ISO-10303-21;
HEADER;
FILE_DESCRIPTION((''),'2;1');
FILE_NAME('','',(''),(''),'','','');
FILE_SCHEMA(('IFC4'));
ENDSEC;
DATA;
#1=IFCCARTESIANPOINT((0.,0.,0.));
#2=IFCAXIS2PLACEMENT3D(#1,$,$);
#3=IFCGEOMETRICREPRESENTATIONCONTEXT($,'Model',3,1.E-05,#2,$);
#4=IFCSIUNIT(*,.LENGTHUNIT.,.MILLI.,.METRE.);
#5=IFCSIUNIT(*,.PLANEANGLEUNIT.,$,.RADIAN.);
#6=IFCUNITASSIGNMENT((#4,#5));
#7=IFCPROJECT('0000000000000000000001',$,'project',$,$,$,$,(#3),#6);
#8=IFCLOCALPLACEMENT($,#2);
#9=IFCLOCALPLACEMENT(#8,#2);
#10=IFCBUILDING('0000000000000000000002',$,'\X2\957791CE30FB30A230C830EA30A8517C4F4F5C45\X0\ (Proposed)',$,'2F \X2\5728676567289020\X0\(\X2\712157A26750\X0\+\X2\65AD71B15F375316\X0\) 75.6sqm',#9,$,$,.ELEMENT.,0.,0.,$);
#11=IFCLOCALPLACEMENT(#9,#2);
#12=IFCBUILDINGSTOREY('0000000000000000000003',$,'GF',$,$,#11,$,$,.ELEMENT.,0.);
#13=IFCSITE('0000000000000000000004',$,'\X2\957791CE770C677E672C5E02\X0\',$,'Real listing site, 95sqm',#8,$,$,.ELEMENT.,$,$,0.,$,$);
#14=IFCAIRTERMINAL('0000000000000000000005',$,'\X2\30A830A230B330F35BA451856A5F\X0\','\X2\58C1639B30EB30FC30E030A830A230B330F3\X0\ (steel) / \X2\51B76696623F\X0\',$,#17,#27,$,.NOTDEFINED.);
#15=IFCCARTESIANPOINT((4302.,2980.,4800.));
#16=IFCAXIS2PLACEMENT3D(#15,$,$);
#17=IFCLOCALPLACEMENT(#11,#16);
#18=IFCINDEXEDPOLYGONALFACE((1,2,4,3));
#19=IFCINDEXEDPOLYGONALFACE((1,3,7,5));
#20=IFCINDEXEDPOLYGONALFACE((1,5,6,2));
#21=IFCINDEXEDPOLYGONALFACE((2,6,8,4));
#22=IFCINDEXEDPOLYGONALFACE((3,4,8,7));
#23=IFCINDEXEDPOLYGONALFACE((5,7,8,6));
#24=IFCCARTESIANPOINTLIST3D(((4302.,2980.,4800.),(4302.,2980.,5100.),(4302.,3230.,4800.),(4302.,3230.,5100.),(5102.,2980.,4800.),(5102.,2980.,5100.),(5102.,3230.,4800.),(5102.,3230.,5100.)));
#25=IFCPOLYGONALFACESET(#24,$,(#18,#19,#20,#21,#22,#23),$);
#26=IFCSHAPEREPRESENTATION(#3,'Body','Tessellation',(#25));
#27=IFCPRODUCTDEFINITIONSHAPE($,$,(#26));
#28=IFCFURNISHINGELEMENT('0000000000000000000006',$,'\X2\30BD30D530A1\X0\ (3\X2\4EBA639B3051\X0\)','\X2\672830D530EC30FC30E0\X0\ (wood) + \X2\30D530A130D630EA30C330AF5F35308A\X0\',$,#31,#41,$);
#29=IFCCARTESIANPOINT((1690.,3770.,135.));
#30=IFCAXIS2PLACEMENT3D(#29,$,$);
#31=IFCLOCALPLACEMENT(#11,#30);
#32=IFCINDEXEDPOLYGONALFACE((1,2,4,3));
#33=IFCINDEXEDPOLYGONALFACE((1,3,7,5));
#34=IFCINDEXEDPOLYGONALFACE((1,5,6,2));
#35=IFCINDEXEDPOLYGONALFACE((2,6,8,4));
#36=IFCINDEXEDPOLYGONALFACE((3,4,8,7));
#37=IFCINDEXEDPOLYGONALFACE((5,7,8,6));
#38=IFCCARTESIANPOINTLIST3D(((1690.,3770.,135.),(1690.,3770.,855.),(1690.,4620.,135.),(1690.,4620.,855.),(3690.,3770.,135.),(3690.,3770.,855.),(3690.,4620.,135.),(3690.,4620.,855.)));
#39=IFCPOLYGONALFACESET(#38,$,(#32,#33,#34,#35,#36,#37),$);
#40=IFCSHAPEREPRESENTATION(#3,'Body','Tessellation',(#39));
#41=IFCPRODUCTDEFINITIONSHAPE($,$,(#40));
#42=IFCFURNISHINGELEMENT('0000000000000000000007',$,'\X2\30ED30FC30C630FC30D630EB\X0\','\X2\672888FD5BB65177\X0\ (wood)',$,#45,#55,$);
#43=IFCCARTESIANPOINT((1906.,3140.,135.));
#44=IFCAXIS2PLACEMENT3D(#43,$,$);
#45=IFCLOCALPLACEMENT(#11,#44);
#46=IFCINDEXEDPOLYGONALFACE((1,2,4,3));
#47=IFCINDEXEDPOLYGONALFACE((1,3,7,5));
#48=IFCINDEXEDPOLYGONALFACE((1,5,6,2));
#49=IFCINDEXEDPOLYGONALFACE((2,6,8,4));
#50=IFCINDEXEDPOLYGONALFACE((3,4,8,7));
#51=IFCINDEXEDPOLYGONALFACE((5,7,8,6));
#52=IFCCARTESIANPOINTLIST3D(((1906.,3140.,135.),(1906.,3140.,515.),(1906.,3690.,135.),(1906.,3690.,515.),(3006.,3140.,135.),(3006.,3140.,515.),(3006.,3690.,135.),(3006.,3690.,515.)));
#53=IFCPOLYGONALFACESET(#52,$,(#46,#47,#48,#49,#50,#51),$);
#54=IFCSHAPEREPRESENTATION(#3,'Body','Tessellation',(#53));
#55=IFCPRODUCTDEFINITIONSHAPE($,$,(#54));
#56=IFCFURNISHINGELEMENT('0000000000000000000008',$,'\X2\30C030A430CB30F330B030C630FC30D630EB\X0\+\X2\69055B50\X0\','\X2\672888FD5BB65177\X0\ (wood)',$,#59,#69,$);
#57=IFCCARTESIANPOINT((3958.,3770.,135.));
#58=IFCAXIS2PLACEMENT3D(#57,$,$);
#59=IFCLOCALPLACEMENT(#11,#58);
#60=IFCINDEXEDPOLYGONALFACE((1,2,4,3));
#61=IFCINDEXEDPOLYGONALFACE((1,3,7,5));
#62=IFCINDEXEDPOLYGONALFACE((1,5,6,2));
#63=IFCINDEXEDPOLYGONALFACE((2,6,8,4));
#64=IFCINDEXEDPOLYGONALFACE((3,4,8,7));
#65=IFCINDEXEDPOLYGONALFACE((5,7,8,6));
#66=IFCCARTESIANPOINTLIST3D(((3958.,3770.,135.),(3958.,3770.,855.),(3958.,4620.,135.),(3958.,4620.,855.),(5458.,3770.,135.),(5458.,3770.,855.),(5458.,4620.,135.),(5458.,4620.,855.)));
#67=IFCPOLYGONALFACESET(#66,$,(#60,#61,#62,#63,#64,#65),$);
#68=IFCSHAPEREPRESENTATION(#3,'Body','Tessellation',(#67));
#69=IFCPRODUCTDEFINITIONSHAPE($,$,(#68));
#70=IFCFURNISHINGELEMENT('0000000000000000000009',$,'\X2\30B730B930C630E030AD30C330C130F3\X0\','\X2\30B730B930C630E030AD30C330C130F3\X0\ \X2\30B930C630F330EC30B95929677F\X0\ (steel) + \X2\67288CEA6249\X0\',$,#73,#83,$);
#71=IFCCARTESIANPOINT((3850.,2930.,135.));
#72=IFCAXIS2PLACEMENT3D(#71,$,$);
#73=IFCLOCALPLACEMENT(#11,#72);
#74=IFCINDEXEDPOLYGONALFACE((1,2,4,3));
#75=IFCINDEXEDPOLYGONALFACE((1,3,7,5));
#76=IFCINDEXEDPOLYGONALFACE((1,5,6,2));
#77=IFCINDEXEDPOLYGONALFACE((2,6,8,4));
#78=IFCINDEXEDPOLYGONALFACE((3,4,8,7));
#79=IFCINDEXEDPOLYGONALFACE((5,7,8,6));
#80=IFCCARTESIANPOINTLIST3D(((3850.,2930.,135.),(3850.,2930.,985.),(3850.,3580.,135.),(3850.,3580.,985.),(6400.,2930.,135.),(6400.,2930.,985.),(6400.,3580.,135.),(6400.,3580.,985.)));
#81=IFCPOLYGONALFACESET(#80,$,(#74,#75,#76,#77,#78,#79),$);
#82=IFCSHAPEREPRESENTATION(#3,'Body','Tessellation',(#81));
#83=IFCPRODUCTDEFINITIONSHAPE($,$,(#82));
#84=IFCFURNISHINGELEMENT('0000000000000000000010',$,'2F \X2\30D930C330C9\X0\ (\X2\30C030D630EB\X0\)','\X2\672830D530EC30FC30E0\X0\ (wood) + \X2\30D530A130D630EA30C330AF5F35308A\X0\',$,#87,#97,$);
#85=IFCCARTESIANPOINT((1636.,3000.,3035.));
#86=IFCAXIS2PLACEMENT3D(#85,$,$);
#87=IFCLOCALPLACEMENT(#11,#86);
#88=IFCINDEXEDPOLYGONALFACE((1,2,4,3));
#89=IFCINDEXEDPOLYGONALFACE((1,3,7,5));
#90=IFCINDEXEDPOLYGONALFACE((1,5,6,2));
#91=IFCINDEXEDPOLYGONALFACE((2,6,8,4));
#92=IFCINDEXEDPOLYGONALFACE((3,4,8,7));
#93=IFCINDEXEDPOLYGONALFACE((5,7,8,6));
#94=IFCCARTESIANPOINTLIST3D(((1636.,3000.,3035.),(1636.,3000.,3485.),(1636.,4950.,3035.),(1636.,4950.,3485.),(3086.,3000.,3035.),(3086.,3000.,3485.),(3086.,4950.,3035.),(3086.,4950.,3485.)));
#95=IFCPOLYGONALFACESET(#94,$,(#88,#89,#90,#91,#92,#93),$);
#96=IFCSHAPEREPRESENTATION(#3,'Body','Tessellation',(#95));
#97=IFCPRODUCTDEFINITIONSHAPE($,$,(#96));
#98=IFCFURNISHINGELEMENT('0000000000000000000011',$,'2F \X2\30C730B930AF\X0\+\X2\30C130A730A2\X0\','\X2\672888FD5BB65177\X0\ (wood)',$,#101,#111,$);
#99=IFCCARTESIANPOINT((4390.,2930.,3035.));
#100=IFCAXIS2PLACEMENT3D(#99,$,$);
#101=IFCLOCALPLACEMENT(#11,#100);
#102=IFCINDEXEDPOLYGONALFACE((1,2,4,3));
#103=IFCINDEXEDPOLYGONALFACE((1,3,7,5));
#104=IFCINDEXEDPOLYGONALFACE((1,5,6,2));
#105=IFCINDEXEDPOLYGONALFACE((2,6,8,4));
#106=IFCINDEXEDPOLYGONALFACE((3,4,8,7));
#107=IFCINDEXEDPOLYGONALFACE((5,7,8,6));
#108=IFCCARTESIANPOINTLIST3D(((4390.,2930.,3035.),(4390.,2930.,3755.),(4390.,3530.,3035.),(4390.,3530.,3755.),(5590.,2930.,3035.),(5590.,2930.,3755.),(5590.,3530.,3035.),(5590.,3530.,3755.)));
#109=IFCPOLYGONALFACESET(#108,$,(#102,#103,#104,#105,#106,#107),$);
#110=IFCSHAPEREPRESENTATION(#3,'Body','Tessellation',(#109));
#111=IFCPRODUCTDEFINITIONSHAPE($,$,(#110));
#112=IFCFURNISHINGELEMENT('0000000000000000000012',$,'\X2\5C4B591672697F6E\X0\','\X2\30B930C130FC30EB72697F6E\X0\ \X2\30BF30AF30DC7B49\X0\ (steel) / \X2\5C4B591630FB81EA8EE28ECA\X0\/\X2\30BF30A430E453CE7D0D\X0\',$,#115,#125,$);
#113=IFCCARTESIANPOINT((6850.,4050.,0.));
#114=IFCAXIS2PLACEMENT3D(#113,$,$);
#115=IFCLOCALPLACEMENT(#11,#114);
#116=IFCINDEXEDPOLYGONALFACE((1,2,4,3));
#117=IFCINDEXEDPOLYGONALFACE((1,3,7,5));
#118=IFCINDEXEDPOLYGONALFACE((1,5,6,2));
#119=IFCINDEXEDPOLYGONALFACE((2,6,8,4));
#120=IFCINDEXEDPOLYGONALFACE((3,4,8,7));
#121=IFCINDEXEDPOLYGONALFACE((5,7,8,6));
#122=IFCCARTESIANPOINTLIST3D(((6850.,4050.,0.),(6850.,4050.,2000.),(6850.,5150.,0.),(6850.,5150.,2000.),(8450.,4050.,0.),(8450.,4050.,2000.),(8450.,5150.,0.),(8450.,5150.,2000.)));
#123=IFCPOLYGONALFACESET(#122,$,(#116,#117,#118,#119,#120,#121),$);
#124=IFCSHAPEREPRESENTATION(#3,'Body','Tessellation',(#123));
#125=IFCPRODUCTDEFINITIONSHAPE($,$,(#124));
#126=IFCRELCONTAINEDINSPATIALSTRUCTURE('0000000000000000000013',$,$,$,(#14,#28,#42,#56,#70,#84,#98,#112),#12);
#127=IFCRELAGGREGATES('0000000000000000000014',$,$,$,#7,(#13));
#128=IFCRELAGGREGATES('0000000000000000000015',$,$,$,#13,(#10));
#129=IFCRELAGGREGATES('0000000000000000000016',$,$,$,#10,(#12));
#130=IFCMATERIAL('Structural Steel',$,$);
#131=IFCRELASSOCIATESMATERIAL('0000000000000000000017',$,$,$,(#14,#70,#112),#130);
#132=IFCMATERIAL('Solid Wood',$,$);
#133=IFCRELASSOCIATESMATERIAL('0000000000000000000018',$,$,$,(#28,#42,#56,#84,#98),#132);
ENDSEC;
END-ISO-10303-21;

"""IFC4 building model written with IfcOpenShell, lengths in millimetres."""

from ifc_helpers import new_model, si_unit, frame, frame_2d, origin, place, context, project, spatial, rectangle, extrude, material, element, save


model = new_model("IFC4")

# Units and contexts
model_context = context("Model", 3, precision=1e-05, world=origin())
ifc_project = project(units=[si_unit("LENGTHUNIT", "METRE", prefix="MILLI"), si_unit("PLANEANGLEUNIT", "RADIAN")], contexts=[model_context])

# Site, building, storey
site_placement = place(None, origin())
site = spatial("IfcSite", under=ifc_project, at=site_placement, Name="長野県松本市", ObjectType="Real listing site, 95sqm", CompositionType="ELEMENT", RefElevation=0.0)
building_placement = place(site_placement, origin())
building = spatial("IfcBuilding", under=site, at=building_placement, Name="長野・アトリエ兼住居 (Proposed)", ObjectType="2F 在来木造(無垢材+断熱強化) 75.6sqm", CompositionType="ELEMENT", ElevationOfRefHeight=0.0, ElevationOfTerrain=0.0)
storey_placement = place(building_placement, origin())
storey = spatial("IfcBuildingStorey", under=building, at=storey_placement, Name="GF", CompositionType="ELEMENT", Elevation=0.0)

# Shared definitions
ifc_material_1 = material(Name="Solid Wood")

# Shared definitions
ifc_material_2 = material(Name="Structural Steel")

# Air terminal
air_terminal_1_placement = place(storey_placement, frame((4302.0, 2980.0, 4800.0)))
element("IfcAirTerminal", 1, at=air_terminal_1_placement, inside=storey, material=ifc_material_2, Name="エアコン室内機", Description="壁掛ルームエアコン (steel) / 冷暖房", PredefinedType="NOTDEFINED", context=model_context, shape_type="SweptSolid", body=[
    extrude(rectangle(XDim=800.0, YDim=250.0, at=frame_2d((400.0, 125.0))), frame((4302.0, 2980.0, 4800.0)), (0.0, 0.0, 1.0), 300.0),
])

# Furnishing elements
furnishing_1_placement = place(storey_placement, frame((1690.0, 3770.0, 135.0)))
element("IfcFurnishingElement", 2, at=furnishing_1_placement, inside=storey, material=ifc_material_1, Name="ソファ (3人掛け)", Description="木フレーム (wood) + ファブリック張り", context=model_context, shape_type="SweptSolid", body=[
    extrude(rectangle(XDim=2000.0, YDim=850.0, at=frame_2d((1000.0, 425.0))), frame((1690.0, 3770.0, 135.0)), (0.0, 0.0, 1.0), 720.0),
])
furnishing_2_placement = place(storey_placement, frame((1906.0, 3140.0, 135.0)))
element("IfcFurnishingElement", 3, at=furnishing_2_placement, inside=storey, material=ifc_material_1, Name="ローテーブル", Description="木製家具 (wood)", context=model_context, shape_type="SweptSolid", body=[
    extrude(rectangle(XDim=1100.0, YDim=550.0, at=frame_2d((550.0, 275.0))), frame((1906.0, 3140.0, 135.0)), (0.0, 0.0, 1.0), 380.0),
])
furnishing_3_placement = place(storey_placement, frame((3958.0, 3770.0, 135.0)))
element("IfcFurnishingElement", 4, at=furnishing_3_placement, inside=storey, material=ifc_material_1, Name="ダイニングテーブル+椅子", Description="木製家具 (wood)", context=model_context, shape_type="SweptSolid", body=[
    extrude(rectangle(XDim=1500.0, YDim=850.0, at=frame_2d((750.0, 425.0))), frame((3958.0, 3770.0, 135.0)), (0.0, 0.0, 1.0), 720.0),
])
furnishing_4_placement = place(storey_placement, frame((3850.0, 2930.0, 135.0)))
element("IfcFurnishingElement", 5, at=furnishing_4_placement, inside=storey, material=ifc_material_2, Name="システムキッチン", Description="システムキッチン ステンレス天板 (steel) + 木質扉", context=model_context, shape_type="SweptSolid", body=[
    extrude(rectangle(XDim=2550.0, YDim=650.0, at=frame_2d((1275.0, 325.0))), frame((3850.0, 2930.0, 135.0)), (0.0, 0.0, 1.0), 850.0),
])
furnishing_5_placement = place(storey_placement, frame((1636.0, 3000.0, 3035.0)))
element("IfcFurnishingElement", 6, at=furnishing_5_placement, inside=storey, material=ifc_material_1, Name="2F ベッド (ダブル)", Description="木フレーム (wood) + ファブリック張り", context=model_context, shape_type="SweptSolid", body=[
    extrude(rectangle(XDim=1450.0, YDim=1950.0, at=frame_2d((725.0, 975.0))), frame((1636.0, 3000.0, 3035.0)), (0.0, 0.0, 1.0), 450.0),
])
furnishing_6_placement = place(storey_placement, frame((4390.0, 2930.0, 3035.0)))
element("IfcFurnishingElement", 7, at=furnishing_6_placement, inside=storey, material=ifc_material_1, Name="2F デスク+チェア", Description="木製家具 (wood)", context=model_context, shape_type="SweptSolid", body=[
    extrude(rectangle(XDim=1200.0, YDim=600.0, at=frame_2d((600.0, 300.0))), frame((4390.0, 2930.0, 3035.0)), (0.0, 0.0, 1.0), 720.0),
])
furnishing_7_placement = place(storey_placement, frame((6850.0, 4050.0, 0.0)))
element("IfcFurnishingElement", 8, at=furnishing_7_placement, inside=storey, material=ifc_material_2, Name="屋外物置", Description="スチール物置 タクボ等 (steel) / 屋外・自転車/タイヤ収納", context=model_context, shape_type="SweptSolid", body=[
    extrude(rectangle(XDim=1600.0, YDim=1100.0, at=frame_2d((800.0, 550.0))), frame((6850.0, 4050.0, 0.0)), (0.0, 0.0, 1.0), 2000.0),
])

save(model, "model.ifc")
